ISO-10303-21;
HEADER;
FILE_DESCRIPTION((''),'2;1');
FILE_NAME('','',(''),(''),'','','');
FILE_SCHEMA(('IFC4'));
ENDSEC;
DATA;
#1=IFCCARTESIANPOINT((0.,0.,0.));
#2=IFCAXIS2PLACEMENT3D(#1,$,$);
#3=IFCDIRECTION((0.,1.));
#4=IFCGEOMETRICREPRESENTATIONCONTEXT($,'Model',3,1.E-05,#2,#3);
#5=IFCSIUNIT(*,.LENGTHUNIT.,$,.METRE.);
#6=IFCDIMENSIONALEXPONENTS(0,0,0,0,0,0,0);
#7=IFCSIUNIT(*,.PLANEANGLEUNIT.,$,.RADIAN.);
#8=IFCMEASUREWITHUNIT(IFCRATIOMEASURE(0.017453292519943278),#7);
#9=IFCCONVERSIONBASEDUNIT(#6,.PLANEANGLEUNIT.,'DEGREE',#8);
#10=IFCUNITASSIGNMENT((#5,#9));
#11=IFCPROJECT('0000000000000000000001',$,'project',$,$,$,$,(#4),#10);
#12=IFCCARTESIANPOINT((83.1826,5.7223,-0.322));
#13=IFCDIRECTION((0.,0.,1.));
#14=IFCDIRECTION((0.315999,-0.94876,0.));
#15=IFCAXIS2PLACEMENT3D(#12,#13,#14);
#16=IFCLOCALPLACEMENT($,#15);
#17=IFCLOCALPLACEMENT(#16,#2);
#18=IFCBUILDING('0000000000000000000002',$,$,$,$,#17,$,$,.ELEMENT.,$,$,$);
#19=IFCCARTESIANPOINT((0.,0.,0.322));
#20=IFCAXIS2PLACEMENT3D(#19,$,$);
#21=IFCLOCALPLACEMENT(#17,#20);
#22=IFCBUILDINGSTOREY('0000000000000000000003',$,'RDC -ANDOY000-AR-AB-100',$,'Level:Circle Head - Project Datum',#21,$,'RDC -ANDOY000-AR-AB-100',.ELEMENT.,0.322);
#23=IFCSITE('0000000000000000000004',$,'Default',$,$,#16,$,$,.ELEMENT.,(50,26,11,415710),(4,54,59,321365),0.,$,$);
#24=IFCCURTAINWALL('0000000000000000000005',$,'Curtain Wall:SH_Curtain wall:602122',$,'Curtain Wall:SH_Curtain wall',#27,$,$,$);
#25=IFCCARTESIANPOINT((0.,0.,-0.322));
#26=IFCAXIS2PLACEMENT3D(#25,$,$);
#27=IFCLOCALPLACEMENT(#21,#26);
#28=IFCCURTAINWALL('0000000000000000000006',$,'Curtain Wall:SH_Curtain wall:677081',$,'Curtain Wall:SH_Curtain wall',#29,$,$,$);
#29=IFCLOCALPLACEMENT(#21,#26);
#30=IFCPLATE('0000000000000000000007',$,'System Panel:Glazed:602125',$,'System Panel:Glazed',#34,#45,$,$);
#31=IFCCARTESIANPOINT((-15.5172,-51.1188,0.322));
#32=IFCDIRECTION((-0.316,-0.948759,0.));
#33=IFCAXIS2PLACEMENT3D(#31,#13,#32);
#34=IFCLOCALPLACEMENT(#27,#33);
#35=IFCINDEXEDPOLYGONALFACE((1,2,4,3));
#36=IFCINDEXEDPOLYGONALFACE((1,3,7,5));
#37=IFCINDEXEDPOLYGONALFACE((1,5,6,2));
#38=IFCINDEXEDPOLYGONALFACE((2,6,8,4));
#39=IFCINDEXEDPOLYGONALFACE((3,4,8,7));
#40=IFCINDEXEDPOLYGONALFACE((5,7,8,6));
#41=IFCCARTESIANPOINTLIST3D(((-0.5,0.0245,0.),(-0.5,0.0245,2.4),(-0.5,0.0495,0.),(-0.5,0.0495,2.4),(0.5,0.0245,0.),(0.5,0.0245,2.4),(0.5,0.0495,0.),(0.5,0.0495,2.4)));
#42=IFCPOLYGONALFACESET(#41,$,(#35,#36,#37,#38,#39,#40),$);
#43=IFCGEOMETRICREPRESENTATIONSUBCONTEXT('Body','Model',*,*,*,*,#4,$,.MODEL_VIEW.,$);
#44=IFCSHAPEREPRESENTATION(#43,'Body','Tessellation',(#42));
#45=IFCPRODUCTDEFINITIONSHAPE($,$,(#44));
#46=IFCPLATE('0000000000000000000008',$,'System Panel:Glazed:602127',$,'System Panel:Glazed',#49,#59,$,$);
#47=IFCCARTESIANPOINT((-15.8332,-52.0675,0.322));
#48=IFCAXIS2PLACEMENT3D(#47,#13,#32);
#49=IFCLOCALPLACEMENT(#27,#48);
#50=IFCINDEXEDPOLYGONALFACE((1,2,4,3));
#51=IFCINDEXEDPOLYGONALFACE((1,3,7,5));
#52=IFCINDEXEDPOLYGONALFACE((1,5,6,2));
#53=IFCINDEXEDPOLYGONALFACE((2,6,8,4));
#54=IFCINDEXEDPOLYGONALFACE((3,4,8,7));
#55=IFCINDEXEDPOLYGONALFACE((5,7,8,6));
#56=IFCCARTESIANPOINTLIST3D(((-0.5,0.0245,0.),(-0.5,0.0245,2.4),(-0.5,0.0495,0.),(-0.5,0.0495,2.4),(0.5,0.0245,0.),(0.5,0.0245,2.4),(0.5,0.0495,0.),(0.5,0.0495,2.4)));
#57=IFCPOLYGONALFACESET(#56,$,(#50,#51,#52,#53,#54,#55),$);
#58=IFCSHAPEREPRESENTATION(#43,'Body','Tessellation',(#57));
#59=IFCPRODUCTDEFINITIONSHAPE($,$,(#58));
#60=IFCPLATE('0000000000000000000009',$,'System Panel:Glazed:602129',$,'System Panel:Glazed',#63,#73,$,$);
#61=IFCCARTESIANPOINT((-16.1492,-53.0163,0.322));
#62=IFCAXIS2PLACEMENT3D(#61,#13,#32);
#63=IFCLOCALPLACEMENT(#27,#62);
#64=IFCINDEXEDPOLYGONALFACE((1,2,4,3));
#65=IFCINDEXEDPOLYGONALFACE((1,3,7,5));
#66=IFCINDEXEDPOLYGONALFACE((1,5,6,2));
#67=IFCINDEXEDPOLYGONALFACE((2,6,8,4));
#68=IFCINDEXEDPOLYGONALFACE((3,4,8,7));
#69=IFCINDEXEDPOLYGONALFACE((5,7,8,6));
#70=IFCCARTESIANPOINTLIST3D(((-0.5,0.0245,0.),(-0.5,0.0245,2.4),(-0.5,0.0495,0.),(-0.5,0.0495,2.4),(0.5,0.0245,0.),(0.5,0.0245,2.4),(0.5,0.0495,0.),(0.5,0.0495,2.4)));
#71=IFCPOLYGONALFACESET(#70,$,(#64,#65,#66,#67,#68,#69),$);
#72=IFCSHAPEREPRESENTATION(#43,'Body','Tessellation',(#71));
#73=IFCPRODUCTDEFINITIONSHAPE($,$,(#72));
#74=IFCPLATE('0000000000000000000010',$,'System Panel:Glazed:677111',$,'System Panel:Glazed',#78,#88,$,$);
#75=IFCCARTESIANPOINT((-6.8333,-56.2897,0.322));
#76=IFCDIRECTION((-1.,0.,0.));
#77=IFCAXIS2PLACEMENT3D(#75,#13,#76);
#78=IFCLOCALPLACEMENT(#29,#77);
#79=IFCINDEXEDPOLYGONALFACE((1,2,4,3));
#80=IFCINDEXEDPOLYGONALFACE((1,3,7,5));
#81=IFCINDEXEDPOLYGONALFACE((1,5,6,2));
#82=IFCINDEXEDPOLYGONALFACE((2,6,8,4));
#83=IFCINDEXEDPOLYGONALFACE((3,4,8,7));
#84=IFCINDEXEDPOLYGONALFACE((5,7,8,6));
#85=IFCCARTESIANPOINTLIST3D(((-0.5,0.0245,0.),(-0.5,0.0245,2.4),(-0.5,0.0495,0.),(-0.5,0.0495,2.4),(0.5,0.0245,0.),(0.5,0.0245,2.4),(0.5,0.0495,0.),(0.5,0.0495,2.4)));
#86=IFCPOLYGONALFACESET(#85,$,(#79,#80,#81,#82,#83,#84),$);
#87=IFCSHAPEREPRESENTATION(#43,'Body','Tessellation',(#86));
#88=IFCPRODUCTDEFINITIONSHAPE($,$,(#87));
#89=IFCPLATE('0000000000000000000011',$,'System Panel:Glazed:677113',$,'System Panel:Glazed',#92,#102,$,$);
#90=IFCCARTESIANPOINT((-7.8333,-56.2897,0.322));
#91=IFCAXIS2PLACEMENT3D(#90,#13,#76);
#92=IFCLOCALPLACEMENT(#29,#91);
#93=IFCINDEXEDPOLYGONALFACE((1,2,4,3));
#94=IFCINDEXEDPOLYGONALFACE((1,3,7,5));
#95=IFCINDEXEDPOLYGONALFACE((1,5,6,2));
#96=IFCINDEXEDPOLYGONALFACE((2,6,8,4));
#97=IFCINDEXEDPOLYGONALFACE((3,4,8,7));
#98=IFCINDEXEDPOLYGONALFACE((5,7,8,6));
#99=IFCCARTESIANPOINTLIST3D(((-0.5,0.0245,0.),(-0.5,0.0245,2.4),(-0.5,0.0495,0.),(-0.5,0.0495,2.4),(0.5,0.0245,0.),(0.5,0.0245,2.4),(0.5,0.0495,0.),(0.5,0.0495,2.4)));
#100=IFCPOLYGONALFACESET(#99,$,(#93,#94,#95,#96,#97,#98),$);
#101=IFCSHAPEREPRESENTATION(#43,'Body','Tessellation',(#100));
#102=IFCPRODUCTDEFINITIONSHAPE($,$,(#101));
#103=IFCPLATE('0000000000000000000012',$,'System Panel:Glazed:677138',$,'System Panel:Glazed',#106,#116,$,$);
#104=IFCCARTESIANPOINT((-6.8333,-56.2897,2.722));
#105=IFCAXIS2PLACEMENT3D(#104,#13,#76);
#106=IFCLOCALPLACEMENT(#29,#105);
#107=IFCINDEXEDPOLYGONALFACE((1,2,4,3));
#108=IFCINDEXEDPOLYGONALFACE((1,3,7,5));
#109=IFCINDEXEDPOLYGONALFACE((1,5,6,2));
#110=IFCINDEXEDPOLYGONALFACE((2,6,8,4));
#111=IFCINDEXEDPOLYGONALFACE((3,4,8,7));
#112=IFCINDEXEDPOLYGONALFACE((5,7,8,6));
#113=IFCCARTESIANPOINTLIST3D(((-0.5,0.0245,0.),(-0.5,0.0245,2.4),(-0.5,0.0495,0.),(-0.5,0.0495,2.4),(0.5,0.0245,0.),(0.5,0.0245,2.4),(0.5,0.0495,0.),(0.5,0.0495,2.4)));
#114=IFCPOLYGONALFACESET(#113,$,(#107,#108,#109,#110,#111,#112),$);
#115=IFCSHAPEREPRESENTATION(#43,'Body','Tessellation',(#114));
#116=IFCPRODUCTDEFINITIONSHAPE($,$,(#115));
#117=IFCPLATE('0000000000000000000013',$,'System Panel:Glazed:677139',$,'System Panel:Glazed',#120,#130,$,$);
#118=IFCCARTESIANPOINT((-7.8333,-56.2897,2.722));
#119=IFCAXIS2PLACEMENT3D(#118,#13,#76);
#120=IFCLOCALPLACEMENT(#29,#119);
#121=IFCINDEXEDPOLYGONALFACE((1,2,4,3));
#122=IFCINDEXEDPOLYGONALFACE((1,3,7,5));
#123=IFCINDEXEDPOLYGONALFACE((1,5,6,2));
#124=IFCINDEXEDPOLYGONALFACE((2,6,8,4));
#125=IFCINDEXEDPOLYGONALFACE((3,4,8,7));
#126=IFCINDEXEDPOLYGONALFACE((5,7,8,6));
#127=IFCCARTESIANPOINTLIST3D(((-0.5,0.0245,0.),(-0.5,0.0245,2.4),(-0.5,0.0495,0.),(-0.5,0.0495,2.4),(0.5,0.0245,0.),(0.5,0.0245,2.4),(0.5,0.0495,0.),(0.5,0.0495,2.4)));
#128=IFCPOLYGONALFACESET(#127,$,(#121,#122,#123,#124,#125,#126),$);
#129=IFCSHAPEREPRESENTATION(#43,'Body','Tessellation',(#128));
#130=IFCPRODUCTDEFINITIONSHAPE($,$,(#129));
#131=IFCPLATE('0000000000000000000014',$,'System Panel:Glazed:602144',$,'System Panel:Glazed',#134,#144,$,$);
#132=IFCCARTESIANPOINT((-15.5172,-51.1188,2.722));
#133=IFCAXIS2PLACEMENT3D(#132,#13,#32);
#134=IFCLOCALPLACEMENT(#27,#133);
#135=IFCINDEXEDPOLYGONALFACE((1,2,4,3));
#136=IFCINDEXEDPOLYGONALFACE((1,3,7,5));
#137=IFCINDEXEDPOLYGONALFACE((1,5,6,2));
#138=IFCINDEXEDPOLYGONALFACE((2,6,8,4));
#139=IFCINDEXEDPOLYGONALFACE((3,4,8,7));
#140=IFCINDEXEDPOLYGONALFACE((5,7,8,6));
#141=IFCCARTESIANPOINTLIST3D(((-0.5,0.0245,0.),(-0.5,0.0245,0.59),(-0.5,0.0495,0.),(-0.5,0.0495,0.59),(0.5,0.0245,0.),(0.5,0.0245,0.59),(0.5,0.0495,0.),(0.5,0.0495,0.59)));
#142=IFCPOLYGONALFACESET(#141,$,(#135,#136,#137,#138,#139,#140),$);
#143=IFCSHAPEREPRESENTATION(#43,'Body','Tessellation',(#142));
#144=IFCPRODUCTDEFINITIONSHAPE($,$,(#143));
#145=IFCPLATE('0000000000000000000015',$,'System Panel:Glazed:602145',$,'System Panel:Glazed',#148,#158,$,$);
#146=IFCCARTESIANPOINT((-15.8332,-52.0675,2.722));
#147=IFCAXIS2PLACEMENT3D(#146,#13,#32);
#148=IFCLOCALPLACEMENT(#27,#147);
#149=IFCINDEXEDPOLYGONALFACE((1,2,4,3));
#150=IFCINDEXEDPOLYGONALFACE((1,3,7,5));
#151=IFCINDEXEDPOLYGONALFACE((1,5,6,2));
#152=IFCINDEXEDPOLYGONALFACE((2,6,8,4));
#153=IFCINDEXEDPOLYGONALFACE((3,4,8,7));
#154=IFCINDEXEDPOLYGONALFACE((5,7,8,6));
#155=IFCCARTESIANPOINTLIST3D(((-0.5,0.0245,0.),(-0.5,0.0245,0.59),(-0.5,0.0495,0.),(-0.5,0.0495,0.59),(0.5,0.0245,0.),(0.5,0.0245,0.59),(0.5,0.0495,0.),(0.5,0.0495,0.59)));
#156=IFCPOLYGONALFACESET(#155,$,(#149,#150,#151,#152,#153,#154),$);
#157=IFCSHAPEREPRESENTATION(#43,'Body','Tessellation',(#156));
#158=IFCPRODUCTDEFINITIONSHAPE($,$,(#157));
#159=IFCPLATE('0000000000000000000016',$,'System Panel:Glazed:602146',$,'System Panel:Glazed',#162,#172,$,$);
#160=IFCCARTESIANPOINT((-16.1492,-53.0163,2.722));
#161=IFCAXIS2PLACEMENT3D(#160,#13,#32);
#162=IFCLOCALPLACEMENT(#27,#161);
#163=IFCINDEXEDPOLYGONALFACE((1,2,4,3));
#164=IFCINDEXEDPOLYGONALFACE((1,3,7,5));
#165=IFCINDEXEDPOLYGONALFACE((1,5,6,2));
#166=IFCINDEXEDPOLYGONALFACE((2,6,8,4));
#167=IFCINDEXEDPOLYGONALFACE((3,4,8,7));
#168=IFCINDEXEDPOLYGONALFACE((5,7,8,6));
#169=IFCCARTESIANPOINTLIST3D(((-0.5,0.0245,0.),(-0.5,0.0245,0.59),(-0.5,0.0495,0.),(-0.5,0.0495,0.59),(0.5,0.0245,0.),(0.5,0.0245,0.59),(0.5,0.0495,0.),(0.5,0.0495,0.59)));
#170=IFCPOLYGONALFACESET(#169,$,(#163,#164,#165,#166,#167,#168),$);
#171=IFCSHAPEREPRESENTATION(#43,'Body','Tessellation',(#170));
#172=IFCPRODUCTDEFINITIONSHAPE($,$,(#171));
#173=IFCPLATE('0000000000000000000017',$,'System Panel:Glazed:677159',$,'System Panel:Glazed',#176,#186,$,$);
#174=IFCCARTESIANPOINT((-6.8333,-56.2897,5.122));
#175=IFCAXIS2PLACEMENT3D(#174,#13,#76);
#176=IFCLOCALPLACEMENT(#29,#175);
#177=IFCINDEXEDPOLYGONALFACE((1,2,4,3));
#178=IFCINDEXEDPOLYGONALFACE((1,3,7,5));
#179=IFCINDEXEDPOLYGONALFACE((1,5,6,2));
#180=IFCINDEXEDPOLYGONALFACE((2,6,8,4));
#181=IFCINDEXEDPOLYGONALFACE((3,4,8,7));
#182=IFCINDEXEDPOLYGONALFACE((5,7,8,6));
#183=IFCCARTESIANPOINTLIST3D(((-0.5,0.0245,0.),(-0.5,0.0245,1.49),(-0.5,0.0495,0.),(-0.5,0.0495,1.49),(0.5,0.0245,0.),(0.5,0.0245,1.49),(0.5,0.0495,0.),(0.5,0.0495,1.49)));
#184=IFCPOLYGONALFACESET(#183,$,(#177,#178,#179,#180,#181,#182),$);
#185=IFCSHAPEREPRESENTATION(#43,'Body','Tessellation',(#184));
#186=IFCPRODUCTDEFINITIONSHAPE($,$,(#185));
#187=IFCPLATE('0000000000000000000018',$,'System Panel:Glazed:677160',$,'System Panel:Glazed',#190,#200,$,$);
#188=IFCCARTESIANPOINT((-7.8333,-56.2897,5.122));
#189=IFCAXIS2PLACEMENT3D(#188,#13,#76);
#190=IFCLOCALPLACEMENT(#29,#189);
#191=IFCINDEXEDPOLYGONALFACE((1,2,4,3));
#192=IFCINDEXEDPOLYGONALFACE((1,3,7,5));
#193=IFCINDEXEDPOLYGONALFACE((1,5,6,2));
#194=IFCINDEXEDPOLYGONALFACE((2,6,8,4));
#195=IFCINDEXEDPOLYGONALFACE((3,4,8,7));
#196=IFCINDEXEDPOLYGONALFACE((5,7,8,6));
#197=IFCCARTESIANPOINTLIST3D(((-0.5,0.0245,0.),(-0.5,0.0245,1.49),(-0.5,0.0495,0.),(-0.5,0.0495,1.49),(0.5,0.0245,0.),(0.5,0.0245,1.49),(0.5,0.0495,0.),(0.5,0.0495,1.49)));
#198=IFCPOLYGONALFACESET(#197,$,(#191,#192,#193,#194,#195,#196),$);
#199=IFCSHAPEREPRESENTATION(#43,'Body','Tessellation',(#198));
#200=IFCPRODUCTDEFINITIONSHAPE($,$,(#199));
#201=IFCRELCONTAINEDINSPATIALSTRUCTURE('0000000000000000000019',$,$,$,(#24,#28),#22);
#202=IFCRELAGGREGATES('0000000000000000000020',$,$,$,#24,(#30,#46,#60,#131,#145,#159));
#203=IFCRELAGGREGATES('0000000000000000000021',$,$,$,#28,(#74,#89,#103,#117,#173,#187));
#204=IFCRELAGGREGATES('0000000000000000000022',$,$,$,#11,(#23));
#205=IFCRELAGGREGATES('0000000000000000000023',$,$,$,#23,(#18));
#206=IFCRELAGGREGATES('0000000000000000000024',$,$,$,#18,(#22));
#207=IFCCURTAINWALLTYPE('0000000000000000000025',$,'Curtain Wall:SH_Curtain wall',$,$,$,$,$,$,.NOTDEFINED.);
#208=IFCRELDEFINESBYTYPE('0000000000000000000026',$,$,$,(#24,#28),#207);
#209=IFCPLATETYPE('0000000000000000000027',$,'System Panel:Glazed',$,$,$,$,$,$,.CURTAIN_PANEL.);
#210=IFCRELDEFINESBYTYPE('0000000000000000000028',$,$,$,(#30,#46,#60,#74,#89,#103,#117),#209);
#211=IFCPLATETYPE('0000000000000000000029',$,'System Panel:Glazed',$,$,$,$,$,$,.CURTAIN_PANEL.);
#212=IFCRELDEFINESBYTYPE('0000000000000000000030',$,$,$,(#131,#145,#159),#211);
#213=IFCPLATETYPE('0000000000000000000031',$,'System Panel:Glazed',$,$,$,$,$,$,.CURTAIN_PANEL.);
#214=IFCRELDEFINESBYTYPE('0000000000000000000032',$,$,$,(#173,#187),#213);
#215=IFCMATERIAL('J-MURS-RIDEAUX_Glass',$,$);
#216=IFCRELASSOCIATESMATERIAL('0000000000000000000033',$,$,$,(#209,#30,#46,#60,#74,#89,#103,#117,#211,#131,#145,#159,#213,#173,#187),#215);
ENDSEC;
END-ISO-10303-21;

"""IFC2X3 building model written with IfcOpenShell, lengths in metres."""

from ifc_helpers import new_model, entity, si_unit, converted_unit, direction, frame, frame_2d, origin, origin_2d_with_axis, place, context, subcontext, project, spatial, rectangle, extrude, source, transform, mapped, material, type_object, type_shapes, element, aggregate, save


model = new_model("IFC2X3")

# Units and contexts
model_context = context("Model", 3, precision=1e-05, world=origin(), true_north=direction((0.0, 1.0)))
body_context = subcontext(model_context, "Body", "Model", "MODEL_VIEW")
ifc_project = project(units=[si_unit("LENGTHUNIT", "METRE"), converted_unit("PLANEANGLEUNIT", "DEGREE", entity("IfcRatioMeasure", 0.017453292519943278), si_unit("PLANEANGLEUNIT", "RADIAN"), dimensions=[0, 0, 0, 0, 0, 0, 0])], contexts=[model_context])

# Site, building, storey
site_placement = place(None, frame((83.1826, 5.7223, -0.322), z_axis=(0.0, 0.0, 1.0), x_axis=(0.315999, -0.94876, 0.0)))
site = spatial("IfcSite", under=ifc_project, at=site_placement, Name="Default", CompositionType="ELEMENT", RefLatitude=(50, 26, 11, 415710), RefLongitude=(4, 54, 59, 321365), RefElevation=0.0)
building_placement = place(site_placement, origin())
building = spatial("IfcBuilding", under=site, at=building_placement, CompositionType="ELEMENT")
storey_placement = place(building_placement, frame((0.0, 0.0, 0.322)))
storey = spatial("IfcBuildingStorey", under=building, at=storey_placement, Name="RDC -ANDOY000-AR-AB-100", ObjectType="Level:Circle Head - Project Datum", LongName="RDC -ANDOY000-AR-AB-100", CompositionType="ELEMENT", Elevation=0.322)

# Curtain wall
curtain_wall_type = type_object("IfcCurtainWallType", Name="Curtain Wall:SH_Curtain wall", PredefinedType="NOTDEFINED")
curtain_wall_1_placement = place(storey_placement, frame((0.0, 0.0, -0.322)))
curtain_wall_1 = element("IfcCurtainWall", 1, at=curtain_wall_1_placement, inside=storey, type_object=curtain_wall_type, Name="Curtain Wall:SH_Curtain wall:602122", ObjectType="Curtain Wall:SH_Curtain wall")

# Curtain wall
curtain_wall_2_placement = place(storey_placement, frame((0.0, 0.0, -0.322)))
curtain_wall_2 = element("IfcCurtainWall", 2, at=curtain_wall_2_placement, inside=storey, type_object=curtain_wall_type, Name="Curtain Wall:SH_Curtain wall:677081", ObjectType="Curtain Wall:SH_Curtain wall")

# Plates
ifc_material_1 = material(Name="J-MURS-RIDEAUX_Glass")
plate_type_1 = type_object("IfcPlateType", Name="System Panel:Glazed", PredefinedType="CURTAIN_PANEL", material=ifc_material_1)
shared_shape_1 = source(origin(), body_context, "Body", "SweptSolid", [
    extrude(rectangle(XDim=0.025, YDim=1.0, at=frame_2d((0.0, 0.0), x_axis=(1.0, 0.0))), frame((0.0, 0.037, 0.0), z_axis=(0.0, 0.0, 1.0), x_axis=(0.0, 1.0, 0.0)), (0.0, 0.0, 1.0), 2.4),
])
type_shapes(plate_type_1, [shared_shape_1])
plate_1_placement = place(curtain_wall_1_placement, frame((-15.5172, -51.1188, 0.322), z_axis=(0.0, 0.0, 1.0), x_axis=(-0.316, -0.948759, 0.0)))
plate_1 = element("IfcPlate", 3, at=plate_1_placement, type_object=plate_type_1, material=ifc_material_1, Name="System Panel:Glazed:602125", ObjectType="System Panel:Glazed", context=body_context, shape_type="MappedRepresentation", body=[
    mapped(shared_shape_1, transform((0.0, 0.0, 0.0), scale=1.0)),
])
plate_2_placement = place(curtain_wall_1_placement, frame((-15.8332, -52.0675, 0.322), z_axis=(0.0, 0.0, 1.0), x_axis=(-0.316, -0.948759, 0.0)))
plate_2 = element("IfcPlate", 4, at=plate_2_placement, type_object=plate_type_1, material=ifc_material_1, Name="System Panel:Glazed:602127", ObjectType="System Panel:Glazed", context=body_context, shape_type="MappedRepresentation", body=[
    mapped(shared_shape_1, transform((0.0, 0.0, 0.0), scale=1.0)),
])
plate_3_placement = place(curtain_wall_1_placement, frame((-16.1492, -53.0163, 0.322), z_axis=(0.0, 0.0, 1.0), x_axis=(-0.316, -0.948759, 0.0)))
plate_3 = element("IfcPlate", 5, at=plate_3_placement, type_object=plate_type_1, material=ifc_material_1, Name="System Panel:Glazed:602129", ObjectType="System Panel:Glazed", context=body_context, shape_type="MappedRepresentation", body=[
    mapped(shared_shape_1, transform((0.0, 0.0, 0.0), scale=1.0)),
])
plate_4_placement = place(curtain_wall_2_placement, frame((-6.8333, -56.2897, 0.322), z_axis=(0.0, 0.0, 1.0), x_axis=(-1.0, 0.0, 0.0)))
plate_4 = element("IfcPlate", 6, at=plate_4_placement, type_object=plate_type_1, material=ifc_material_1, Name="System Panel:Glazed:677111", ObjectType="System Panel:Glazed", context=body_context, shape_type="MappedRepresentation", body=[
    mapped(shared_shape_1, transform((0.0, 0.0, 0.0), scale=1.0)),
])
plate_5_placement = place(curtain_wall_2_placement, frame((-7.8333, -56.2897, 0.322), z_axis=(0.0, 0.0, 1.0), x_axis=(-1.0, 0.0, 0.0)))
plate_5 = element("IfcPlate", 7, at=plate_5_placement, type_object=plate_type_1, material=ifc_material_1, Name="System Panel:Glazed:677113", ObjectType="System Panel:Glazed", context=body_context, shape_type="MappedRepresentation", body=[
    mapped(shared_shape_1, transform((0.0, 0.0, 0.0), scale=1.0)),
])
plate_6_placement = place(curtain_wall_2_placement, frame((-6.8333, -56.2897, 2.722), z_axis=(0.0, 0.0, 1.0), x_axis=(-1.0, 0.0, 0.0)))
plate_6 = element("IfcPlate", 8, at=plate_6_placement, type_object=plate_type_1, material=ifc_material_1, Name="System Panel:Glazed:677138", ObjectType="System Panel:Glazed", context=body_context, shape_type="MappedRepresentation", body=[
    mapped(shared_shape_1, transform((0.0, 0.0, 0.0), scale=1.0)),
])
plate_7_placement = place(curtain_wall_2_placement, frame((-7.8333, -56.2897, 2.722), z_axis=(0.0, 0.0, 1.0), x_axis=(-1.0, 0.0, 0.0)))
plate_7 = element("IfcPlate", 9, at=plate_7_placement, type_object=plate_type_1, material=ifc_material_1, Name="System Panel:Glazed:677139", ObjectType="System Panel:Glazed", context=body_context, shape_type="MappedRepresentation", body=[
    mapped(shared_shape_1, transform((0.0, 0.0, 0.0), scale=1.0)),
])
plate_type_2 = type_object("IfcPlateType", Name="System Panel:Glazed", PredefinedType="CURTAIN_PANEL", material=ifc_material_1)
shared_shape_2 = source(origin(), body_context, "Body", "SweptSolid", [
    extrude(rectangle(XDim=0.025, YDim=1.0, at=frame_2d((0.0, 0.0), x_axis=(1.0, 0.0))), frame((0.0, 0.037, 0.0), z_axis=(0.0, 0.0, 1.0), x_axis=(0.0, 1.0, 0.0)), (0.0, 0.0, 1.0), 0.59),
])
type_shapes(plate_type_2, [shared_shape_2])
plate_8_placement = place(curtain_wall_1_placement, frame((-15.5172, -51.1188, 2.722), z_axis=(0.0, 0.0, 1.0), x_axis=(-0.316, -0.948759, 0.0)))
plate_8 = element("IfcPlate", 10, at=plate_8_placement, type_object=plate_type_2, material=ifc_material_1, Name="System Panel:Glazed:602144", ObjectType="System Panel:Glazed", context=body_context, shape_type="MappedRepresentation", body=[
    mapped(shared_shape_2, transform((0.0, 0.0, 0.0), scale=1.0)),
])
plate_9_placement = place(curtain_wall_1_placement, frame((-15.8332, -52.0675, 2.722), z_axis=(0.0, 0.0, 1.0), x_axis=(-0.316, -0.948759, 0.0)))
plate_9 = element("IfcPlate", 11, at=plate_9_placement, type_object=plate_type_2, material=ifc_material_1, Name="System Panel:Glazed:602145", ObjectType="System Panel:Glazed", context=body_context, shape_type="MappedRepresentation", body=[
    mapped(shared_shape_2, transform((0.0, 0.0, 0.0), scale=1.0)),
])
plate_10_placement = place(curtain_wall_1_placement, frame((-16.1492, -53.0163, 2.722), z_axis=(0.0, 0.0, 1.0), x_axis=(-0.316, -0.948759, 0.0)))
plate_10 = element("IfcPlate", 12, at=plate_10_placement, type_object=plate_type_2, material=ifc_material_1, Name="System Panel:Glazed:602146", ObjectType="System Panel:Glazed", context=body_context, shape_type="MappedRepresentation", body=[
    mapped(shared_shape_2, transform((0.0, 0.0, 0.0), scale=1.0)),
])
aggregate(curtain_wall_1, [plate_1, plate_2, plate_3, plate_8, plate_9, plate_10])
plate_type_3 = type_object("IfcPlateType", Name="System Panel:Glazed", PredefinedType="CURTAIN_PANEL", material=ifc_material_1)
shared_shape_3 = source(origin(), body_context, "Body", "SweptSolid", [
    extrude(rectangle(XDim=0.025, YDim=1.0, at=origin_2d_with_axis()), frame((0.0, 0.037, 0.0), z_axis=(0.0, 0.0, 1.0), x_axis=(0.0, 1.0, 0.0)), (0.0, 0.0, 1.0), 1.49),
])
type_shapes(plate_type_3, [shared_shape_3])
plate_11_placement = place(curtain_wall_2_placement, frame((-6.8333, -56.2897, 5.122), z_axis=(0.0, 0.0, 1.0), x_axis=(-1.0, 0.0, 0.0)))
plate_11 = element("IfcPlate", 13, at=plate_11_placement, type_object=plate_type_3, material=ifc_material_1, Name="System Panel:Glazed:677159", ObjectType="System Panel:Glazed", context=body_context, shape_type="MappedRepresentation", body=[
    mapped(shared_shape_3, transform((0.0, 0.0, 0.0), scale=1.0)),
])
plate_12_placement = place(curtain_wall_2_placement, frame((-7.8333, -56.2897, 5.122), z_axis=(0.0, 0.0, 1.0), x_axis=(-1.0, 0.0, 0.0)))
plate_12 = element("IfcPlate", 14, at=plate_12_placement, type_object=plate_type_3, material=ifc_material_1, Name="System Panel:Glazed:677160", ObjectType="System Panel:Glazed", context=body_context, shape_type="MappedRepresentation", body=[
    mapped(shared_shape_3, transform((0.0, 0.0, 0.0), scale=1.0)),
])
aggregate(curtain_wall_2, [plate_4, plate_5, plate_6, plate_7, plate_11, plate_12])

save(model, "model.ifc")
